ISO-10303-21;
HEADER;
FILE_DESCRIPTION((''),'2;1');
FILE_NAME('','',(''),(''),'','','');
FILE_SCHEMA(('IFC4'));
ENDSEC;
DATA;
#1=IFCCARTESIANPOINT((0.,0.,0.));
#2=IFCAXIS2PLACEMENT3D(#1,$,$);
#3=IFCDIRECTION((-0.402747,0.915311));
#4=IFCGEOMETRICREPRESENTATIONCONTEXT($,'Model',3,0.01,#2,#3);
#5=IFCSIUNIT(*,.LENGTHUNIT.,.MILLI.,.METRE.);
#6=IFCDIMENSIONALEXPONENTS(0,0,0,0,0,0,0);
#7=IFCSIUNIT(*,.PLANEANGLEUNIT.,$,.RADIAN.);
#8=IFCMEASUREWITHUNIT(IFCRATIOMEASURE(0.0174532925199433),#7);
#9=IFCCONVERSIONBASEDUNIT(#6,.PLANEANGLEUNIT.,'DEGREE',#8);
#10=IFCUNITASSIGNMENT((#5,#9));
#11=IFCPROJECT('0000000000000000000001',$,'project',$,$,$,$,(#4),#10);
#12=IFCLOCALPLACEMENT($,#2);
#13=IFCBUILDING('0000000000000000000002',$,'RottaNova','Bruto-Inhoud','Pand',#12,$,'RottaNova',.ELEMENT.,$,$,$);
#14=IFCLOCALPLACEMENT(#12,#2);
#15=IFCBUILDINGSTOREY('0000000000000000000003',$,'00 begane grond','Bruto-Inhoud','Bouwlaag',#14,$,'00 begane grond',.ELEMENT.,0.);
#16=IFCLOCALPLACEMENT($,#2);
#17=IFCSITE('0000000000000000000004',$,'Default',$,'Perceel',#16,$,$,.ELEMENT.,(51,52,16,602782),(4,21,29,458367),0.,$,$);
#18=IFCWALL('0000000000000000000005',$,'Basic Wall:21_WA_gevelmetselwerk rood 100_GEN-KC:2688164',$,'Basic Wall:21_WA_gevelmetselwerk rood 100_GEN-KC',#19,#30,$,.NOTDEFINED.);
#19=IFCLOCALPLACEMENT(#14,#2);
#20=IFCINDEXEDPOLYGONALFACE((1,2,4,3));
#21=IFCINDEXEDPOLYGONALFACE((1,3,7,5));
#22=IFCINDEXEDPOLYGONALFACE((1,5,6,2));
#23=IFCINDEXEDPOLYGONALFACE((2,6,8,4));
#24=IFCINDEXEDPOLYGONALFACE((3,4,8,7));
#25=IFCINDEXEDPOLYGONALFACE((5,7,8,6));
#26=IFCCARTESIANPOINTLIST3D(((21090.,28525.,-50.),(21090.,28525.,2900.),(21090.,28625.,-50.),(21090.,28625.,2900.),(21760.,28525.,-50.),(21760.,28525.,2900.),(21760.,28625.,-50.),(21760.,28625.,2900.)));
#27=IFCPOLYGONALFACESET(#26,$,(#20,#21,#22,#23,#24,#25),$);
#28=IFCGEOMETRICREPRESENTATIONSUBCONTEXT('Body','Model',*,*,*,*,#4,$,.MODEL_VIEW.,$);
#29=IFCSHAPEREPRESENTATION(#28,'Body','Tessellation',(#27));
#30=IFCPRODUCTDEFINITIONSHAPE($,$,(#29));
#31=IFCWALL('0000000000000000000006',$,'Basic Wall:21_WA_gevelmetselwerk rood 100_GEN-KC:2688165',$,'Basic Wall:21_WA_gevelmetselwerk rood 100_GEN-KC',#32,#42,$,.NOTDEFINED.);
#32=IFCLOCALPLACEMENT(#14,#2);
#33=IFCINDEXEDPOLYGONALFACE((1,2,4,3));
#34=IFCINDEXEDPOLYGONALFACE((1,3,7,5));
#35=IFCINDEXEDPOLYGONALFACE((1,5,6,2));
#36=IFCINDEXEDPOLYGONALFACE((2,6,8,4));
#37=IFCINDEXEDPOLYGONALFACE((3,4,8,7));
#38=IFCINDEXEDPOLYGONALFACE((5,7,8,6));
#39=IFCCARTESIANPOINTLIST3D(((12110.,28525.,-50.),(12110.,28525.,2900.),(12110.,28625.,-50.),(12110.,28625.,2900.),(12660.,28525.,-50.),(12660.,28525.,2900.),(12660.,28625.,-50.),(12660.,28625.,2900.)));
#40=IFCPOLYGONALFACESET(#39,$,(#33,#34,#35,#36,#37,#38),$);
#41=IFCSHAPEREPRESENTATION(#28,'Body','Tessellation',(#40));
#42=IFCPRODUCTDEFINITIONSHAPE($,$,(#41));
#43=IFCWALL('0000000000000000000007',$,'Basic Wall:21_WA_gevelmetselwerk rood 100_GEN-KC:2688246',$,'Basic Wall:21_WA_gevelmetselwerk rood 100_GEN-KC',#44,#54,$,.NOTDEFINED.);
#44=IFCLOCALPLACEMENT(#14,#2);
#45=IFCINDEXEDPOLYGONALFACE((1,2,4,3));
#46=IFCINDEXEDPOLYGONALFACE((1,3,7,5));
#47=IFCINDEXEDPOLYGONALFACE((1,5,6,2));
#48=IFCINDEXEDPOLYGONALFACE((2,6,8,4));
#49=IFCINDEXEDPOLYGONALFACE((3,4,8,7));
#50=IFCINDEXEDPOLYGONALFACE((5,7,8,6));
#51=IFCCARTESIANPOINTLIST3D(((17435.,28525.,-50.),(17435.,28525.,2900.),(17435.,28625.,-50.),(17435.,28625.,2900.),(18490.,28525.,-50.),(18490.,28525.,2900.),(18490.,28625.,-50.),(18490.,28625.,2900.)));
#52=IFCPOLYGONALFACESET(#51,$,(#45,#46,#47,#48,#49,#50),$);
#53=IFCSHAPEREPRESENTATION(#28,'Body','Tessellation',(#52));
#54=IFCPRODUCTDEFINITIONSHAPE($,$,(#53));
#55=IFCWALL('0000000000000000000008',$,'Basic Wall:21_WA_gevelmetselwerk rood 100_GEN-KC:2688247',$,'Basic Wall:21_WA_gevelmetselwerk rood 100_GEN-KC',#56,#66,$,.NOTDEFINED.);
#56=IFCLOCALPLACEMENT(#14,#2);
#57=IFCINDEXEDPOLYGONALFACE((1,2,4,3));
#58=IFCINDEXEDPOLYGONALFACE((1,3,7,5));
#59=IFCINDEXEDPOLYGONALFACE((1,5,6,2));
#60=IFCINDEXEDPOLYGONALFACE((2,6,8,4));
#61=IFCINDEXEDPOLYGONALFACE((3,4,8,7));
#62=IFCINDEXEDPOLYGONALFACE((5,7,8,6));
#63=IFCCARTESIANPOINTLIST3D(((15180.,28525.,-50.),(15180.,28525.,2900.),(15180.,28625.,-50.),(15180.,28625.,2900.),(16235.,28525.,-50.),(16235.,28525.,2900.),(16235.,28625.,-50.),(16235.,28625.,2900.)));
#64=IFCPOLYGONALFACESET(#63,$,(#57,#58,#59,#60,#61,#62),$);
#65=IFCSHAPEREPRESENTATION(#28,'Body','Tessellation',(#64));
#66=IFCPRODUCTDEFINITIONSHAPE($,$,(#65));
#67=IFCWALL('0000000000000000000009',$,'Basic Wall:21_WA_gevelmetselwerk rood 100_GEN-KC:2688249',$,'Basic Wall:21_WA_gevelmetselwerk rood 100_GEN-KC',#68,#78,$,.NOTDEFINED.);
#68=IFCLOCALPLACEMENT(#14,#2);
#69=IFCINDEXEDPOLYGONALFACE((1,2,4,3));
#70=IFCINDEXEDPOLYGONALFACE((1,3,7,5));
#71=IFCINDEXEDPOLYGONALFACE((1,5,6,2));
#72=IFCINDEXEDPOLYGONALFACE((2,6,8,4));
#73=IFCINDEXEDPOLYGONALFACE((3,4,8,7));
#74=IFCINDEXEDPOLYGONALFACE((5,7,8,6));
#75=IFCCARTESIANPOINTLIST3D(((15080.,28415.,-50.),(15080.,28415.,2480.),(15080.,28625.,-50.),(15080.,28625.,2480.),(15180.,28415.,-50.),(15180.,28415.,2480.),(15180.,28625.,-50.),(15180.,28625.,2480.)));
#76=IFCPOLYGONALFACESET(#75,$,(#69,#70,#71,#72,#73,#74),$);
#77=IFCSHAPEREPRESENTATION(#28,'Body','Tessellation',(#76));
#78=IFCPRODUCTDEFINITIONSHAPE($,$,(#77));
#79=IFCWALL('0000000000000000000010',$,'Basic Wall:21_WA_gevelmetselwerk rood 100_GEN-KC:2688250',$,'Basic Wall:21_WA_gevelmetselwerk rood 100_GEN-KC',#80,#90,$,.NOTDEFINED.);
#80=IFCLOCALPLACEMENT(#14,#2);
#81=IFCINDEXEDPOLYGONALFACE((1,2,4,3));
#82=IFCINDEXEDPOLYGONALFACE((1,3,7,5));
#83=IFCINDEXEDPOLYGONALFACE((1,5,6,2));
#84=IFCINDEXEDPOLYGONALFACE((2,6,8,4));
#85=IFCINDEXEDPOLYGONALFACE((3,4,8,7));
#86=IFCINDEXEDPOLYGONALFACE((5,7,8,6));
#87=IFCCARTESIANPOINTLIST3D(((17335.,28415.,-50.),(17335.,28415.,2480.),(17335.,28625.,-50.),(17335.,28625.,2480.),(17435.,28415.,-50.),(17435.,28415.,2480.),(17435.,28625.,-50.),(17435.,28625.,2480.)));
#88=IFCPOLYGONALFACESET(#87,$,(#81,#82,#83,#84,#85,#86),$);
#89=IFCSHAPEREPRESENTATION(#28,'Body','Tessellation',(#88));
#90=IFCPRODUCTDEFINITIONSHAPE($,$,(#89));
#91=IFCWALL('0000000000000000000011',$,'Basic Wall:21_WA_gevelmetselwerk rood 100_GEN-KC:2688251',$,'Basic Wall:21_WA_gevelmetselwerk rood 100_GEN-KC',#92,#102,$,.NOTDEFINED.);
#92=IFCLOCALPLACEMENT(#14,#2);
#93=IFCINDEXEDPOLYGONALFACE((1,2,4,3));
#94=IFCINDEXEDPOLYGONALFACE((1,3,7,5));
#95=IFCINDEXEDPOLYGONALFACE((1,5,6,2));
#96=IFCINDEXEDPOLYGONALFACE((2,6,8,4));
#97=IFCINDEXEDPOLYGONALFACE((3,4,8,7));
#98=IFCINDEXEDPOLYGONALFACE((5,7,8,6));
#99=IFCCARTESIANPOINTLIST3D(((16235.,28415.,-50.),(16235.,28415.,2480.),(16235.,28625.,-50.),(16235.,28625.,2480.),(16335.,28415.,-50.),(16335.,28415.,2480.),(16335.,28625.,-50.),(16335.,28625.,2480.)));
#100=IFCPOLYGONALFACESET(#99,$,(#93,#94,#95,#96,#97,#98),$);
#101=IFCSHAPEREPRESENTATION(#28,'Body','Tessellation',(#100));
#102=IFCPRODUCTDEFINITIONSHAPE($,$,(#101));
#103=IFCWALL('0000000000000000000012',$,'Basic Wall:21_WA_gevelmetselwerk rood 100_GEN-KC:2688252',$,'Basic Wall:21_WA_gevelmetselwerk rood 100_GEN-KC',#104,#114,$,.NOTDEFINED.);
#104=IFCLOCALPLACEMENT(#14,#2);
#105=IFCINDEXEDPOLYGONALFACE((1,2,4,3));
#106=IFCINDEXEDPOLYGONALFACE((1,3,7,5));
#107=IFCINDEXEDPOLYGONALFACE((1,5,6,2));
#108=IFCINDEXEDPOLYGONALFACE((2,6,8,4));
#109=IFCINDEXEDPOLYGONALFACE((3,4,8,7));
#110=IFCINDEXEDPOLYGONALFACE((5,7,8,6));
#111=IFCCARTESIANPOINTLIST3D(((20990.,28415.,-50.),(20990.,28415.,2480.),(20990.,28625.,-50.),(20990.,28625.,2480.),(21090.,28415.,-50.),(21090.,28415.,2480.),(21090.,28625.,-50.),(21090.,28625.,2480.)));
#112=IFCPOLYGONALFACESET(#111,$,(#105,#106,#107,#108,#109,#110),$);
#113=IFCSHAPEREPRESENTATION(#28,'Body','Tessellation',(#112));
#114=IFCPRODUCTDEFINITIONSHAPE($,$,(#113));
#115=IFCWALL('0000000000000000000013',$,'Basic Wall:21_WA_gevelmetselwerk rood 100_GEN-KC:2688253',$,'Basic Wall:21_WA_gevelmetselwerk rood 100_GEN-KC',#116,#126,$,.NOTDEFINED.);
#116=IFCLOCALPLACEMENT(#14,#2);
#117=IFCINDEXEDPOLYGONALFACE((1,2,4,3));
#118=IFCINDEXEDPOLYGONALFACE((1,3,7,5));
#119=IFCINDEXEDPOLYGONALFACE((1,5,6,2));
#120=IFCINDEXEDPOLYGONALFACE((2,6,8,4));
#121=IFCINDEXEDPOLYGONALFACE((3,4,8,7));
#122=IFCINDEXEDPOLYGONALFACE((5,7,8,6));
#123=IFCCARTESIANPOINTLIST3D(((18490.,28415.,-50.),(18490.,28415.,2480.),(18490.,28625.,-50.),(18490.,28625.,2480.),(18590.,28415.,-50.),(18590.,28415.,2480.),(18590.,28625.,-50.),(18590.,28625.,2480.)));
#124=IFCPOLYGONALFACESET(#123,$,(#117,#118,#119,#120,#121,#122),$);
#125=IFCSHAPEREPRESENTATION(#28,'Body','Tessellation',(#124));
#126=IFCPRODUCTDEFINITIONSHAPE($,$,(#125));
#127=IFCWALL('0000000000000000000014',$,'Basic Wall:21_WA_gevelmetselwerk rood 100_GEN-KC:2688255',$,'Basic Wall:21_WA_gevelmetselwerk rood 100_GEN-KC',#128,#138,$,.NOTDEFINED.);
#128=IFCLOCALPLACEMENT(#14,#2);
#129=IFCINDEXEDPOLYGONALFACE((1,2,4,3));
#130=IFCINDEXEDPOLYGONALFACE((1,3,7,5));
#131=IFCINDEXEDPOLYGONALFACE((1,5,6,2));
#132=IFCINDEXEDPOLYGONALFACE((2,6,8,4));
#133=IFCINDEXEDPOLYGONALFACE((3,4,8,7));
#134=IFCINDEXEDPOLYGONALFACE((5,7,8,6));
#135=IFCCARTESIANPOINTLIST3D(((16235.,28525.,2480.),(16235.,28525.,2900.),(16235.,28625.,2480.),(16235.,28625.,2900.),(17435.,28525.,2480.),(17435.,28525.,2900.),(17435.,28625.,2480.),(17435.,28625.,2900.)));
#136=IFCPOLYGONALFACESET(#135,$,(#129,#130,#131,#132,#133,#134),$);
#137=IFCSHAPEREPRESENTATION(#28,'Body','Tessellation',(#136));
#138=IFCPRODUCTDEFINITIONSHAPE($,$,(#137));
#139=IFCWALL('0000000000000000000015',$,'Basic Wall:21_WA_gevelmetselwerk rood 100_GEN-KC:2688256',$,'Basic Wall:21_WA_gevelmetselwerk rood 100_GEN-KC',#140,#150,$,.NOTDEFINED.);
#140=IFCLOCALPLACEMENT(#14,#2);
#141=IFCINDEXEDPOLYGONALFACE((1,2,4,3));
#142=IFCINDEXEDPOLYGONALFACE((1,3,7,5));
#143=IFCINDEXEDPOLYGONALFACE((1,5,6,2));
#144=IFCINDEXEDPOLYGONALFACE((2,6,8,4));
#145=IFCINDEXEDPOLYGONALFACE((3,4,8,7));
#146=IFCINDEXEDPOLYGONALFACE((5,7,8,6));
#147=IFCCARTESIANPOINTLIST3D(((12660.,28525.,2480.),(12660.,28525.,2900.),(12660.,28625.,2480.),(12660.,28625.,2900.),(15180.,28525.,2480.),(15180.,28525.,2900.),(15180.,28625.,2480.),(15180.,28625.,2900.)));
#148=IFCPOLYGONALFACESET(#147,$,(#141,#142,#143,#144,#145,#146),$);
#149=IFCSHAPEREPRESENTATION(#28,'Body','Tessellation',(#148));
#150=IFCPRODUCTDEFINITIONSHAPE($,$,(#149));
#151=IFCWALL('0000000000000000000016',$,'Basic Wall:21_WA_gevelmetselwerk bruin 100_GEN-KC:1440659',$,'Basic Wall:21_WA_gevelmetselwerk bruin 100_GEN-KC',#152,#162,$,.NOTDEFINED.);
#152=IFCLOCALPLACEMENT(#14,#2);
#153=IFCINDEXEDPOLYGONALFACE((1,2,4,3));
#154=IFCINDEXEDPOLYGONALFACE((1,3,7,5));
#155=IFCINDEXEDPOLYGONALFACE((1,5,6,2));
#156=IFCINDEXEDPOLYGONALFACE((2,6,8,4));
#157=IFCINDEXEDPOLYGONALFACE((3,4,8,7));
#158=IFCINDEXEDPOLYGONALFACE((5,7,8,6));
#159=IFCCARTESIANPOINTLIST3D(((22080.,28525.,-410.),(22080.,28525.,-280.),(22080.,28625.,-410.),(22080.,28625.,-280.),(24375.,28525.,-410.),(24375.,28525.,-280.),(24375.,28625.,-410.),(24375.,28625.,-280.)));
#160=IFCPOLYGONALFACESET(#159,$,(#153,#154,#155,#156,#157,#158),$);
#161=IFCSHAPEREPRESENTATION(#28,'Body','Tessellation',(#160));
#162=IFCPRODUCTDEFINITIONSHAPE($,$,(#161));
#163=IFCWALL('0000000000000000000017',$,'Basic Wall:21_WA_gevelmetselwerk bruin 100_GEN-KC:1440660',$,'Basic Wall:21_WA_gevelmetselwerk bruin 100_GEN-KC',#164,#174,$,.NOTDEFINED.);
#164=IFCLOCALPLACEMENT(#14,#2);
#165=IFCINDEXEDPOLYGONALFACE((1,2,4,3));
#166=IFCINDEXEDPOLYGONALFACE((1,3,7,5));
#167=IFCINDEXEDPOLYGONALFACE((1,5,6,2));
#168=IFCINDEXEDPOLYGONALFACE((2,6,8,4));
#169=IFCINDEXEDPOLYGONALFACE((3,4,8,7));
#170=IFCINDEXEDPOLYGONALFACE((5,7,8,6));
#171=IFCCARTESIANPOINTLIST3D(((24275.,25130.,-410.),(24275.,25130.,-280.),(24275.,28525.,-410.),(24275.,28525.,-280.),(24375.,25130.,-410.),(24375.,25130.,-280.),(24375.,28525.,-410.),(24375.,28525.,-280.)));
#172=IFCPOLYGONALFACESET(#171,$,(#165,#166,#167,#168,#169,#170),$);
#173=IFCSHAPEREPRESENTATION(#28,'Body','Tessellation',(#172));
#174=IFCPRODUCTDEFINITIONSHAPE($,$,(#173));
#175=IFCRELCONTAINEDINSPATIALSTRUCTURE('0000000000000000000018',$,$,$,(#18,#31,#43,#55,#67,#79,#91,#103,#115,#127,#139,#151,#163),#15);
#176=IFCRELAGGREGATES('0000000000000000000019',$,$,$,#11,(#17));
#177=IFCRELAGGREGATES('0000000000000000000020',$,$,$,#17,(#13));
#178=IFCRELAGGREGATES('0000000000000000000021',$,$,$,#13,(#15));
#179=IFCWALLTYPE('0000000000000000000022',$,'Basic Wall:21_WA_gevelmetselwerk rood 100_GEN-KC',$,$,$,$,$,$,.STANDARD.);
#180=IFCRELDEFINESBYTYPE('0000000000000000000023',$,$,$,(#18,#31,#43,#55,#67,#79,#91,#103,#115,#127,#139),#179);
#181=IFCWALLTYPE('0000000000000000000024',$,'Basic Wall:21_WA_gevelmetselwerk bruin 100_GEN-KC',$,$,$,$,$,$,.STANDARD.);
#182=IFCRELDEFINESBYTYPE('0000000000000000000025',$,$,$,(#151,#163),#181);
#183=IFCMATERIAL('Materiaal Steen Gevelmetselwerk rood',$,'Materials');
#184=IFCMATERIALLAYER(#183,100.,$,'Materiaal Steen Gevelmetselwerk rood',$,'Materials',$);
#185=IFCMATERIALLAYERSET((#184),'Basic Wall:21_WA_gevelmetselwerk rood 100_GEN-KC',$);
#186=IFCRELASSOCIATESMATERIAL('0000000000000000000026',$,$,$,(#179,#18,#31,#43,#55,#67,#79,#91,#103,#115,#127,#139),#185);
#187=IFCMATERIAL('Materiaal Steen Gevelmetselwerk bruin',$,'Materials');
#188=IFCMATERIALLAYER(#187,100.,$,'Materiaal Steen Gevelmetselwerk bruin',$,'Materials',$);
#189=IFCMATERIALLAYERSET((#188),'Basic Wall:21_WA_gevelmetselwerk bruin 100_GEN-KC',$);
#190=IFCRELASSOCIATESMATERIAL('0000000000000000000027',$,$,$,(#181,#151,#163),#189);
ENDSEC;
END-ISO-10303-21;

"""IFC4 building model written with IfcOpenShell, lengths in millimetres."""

from ifc_helpers import new_model, entity, si_unit, converted_unit, direction, frame, frame_2d, origin, place, context, subcontext, project, spatial, rectangle, extrude, material, layer, layer_set, type_object, element, save


model = new_model("IFC4")

# Units and contexts
model_context = context("Model", 3, precision=0.01, world=origin(), true_north=direction((-0.402747, 0.915311)))
body_context = subcontext(model_context, "Body", "Model", "MODEL_VIEW")
ifc_project = project(units=[si_unit("LENGTHUNIT", "METRE", prefix="MILLI"), converted_unit("PLANEANGLEUNIT", "DEGREE", entity("IfcRatioMeasure", 0.0174532925199433), si_unit("PLANEANGLEUNIT", "RADIAN"), dimensions=[0, 0, 0, 0, 0, 0, 0])], contexts=[model_context])

# Site, building, storey
site_placement = place(None, origin())
site = spatial("IfcSite", under=ifc_project, at=site_placement, Name="Default", ObjectType="Perceel", CompositionType="ELEMENT", RefLatitude=(51, 52, 16, 602782), RefLongitude=(4, 21, 29, 458367), RefElevation=0.0)
building_placement = place(None, origin())
building = spatial("IfcBuilding", under=site, at=building_placement, Name="RottaNova", Description="Bruto-Inhoud", ObjectType="Pand", LongName="RottaNova", CompositionType="ELEMENT")
storey_placement = place(building_placement, origin())
storey = spatial("IfcBuildingStorey", under=building, at=storey_placement, Name="00 begane grond", Description="Bruto-Inhoud", ObjectType="Bouwlaag", LongName="00 begane grond", CompositionType="ELEMENT", Elevation=0.0)

# Walls
ifc_material_1 = material(Name="Materiaal Steen Gevelmetselwerk rood", Category="Materials")
ifc_layer_1 = layer(ifc_material_1, 100.0, Name="Materiaal Steen Gevelmetselwerk rood", Category="Materials")
ifc_layer_set_1 = layer_set([ifc_layer_1], Name="Basic Wall:21_WA_gevelmetselwerk rood 100_GEN-KC")
wall_type_1 = type_object("IfcWallType", Name="Basic Wall:21_WA_gevelmetselwerk rood 100_GEN-KC", PredefinedType="STANDARD", material=ifc_layer_set_1)
wall_1_placement = place(storey_placement, frame((21760.0, 28575.0, -50.0), z_axis=(0.0, 0.0, 1.0), x_axis=(-1.0, 0.0, 0.0)))
element("IfcWall", 1, at=wall_1_placement, inside=storey, type_object=wall_type_1, material=ifc_layer_set_1, Name="Basic Wall:21_WA_gevelmetselwerk rood 100_GEN-KC:2688164", ObjectType="Basic Wall:21_WA_gevelmetselwerk rood 100_GEN-KC", PredefinedType="NOTDEFINED", context=body_context, shape_type="SweptSolid", body=[
    extrude(rectangle(XDim=670.0, YDim=100.0, at=frame_2d((335.0, 0.0), x_axis=(-1.0, 0.0))), origin(), (0.0, 0.0, 1.0), 2950.0),
])
wall_2_placement = place(storey_placement, frame((12660.0, 28575.0, -50.0), z_axis=(0.0, 0.0, 1.0), x_axis=(-1.0, 0.0, 0.0)))
element("IfcWall", 2, at=wall_2_placement, inside=storey, type_object=wall_type_1, material=ifc_layer_set_1, Name="Basic Wall:21_WA_gevelmetselwerk rood 100_GEN-KC:2688165", ObjectType="Basic Wall:21_WA_gevelmetselwerk rood 100_GEN-KC", PredefinedType="NOTDEFINED", context=body_context, shape_type="SweptSolid", body=[
    extrude(rectangle(XDim=550.0, YDim=100.0, at=frame_2d((275.0, 0.0), x_axis=(-1.0, 0.0))), origin(), (0.0, 0.0, 1.0), 2950.0),
])
wall_3_placement = place(storey_placement, frame((18490.0, 28575.0, -50.0), z_axis=(0.0, 0.0, 1.0), x_axis=(-1.0, 0.0, 0.0)))
element("IfcWall", 3, at=wall_3_placement, inside=storey, type_object=wall_type_1, material=ifc_layer_set_1, Name="Basic Wall:21_WA_gevelmetselwerk rood 100_GEN-KC:2688246", ObjectType="Basic Wall:21_WA_gevelmetselwerk rood 100_GEN-KC", PredefinedType="NOTDEFINED", context=body_context, shape_type="SweptSolid", body=[
    extrude(rectangle(XDim=1055.0, YDim=100.0, at=frame_2d((527.5, 0.0), x_axis=(-1.0, 0.0))), origin(), (0.0, 0.0, 1.0), 2950.0),
])
wall_4_placement = place(storey_placement, frame((16235.0, 28575.0, -50.0), z_axis=(0.0, 0.0, 1.0), x_axis=(-1.0, 0.0, 0.0)))
element("IfcWall", 4, at=wall_4_placement, inside=storey, type_object=wall_type_1, material=ifc_layer_set_1, Name="Basic Wall:21_WA_gevelmetselwerk rood 100_GEN-KC:2688247", ObjectType="Basic Wall:21_WA_gevelmetselwerk rood 100_GEN-KC", PredefinedType="NOTDEFINED", context=body_context, shape_type="SweptSolid", body=[
    extrude(rectangle(XDim=1055.0, YDim=100.0, at=frame_2d((527.5, 0.0), x_axis=(-1.0, 0.0))), origin(), (0.0, 0.0, 1.0), 2950.0),
])
wall_5_placement = place(storey_placement, frame((15130.0, 28415.0, -50.0), z_axis=(0.0, 0.0, 1.0), x_axis=(0.0, 1.0, 0.0)))
element("IfcWall", 5, at=wall_5_placement, inside=storey, type_object=wall_type_1, material=ifc_layer_set_1, Name="Basic Wall:21_WA_gevelmetselwerk rood 100_GEN-KC:2688249", ObjectType="Basic Wall:21_WA_gevelmetselwerk rood 100_GEN-KC", PredefinedType="NOTDEFINED", context=body_context, shape_type="SweptSolid", body=[
    extrude(rectangle(XDim=210.0, YDim=100.0, at=frame_2d((105.0, 0.0), x_axis=(-1.0, 0.0))), origin(), (0.0, 0.0, 1.0), 2530.0),
])
for number, where, z_axis, x_axis, name in (
    (6, (17385.0, 28415.0, -50.0), (0.0, 0.0, 1.0), (0.0, 1.0, 0.0), "Basic Wall:21_WA_gevelmetselwerk rood 100_GEN-KC:2688250"),
    (7, (16285.0, 28415.0, -50.0), (0.0, 0.0, 1.0), (0.0, 1.0, 0.0), "Basic Wall:21_WA_gevelmetselwerk rood 100_GEN-KC:2688251"),
):
    element("IfcWall", number, at=place(storey_placement, frame(where, z_axis=z_axis, x_axis=x_axis)), inside=storey, type_object=wall_type_1, material=ifc_layer_set_1, Name=name, ObjectType="Basic Wall:21_WA_gevelmetselwerk rood 100_GEN-KC", PredefinedType="NOTDEFINED", context=body_context, shape_type="SweptSolid", body=[
        extrude(rectangle(XDim=210.0, YDim=100.0, at=frame_2d((105.0, 0.0), x_axis=(-1.0, 0.0))), origin(), (0.0, 0.0, 1.0), 2530.0),
    ])
wall_6_placement = place(storey_placement, frame((21040.0, 28415.0, -50.0), z_axis=(0.0, 0.0, 1.0), x_axis=(0.0, 1.0, 0.0)))
element("IfcWall", 8, at=wall_6_placement, inside=storey, type_object=wall_type_1, material=ifc_layer_set_1, Name="Basic Wall:21_WA_gevelmetselwerk rood 100_GEN-KC:2688252", ObjectType="Basic Wall:21_WA_gevelmetselwerk rood 100_GEN-KC", PredefinedType="NOTDEFINED", context=body_context, shape_type="SweptSolid", body=[
    extrude(rectangle(XDim=210.0, YDim=100.0, at=frame_2d((105.0, 0.0), x_axis=(-1.0, 0.0))), origin(), (0.0, 0.0, 1.0), 2530.0),
])
wall_7_placement = place(storey_placement, frame((18540.0, 28415.0, -50.0), z_axis=(0.0, 0.0, 1.0), x_axis=(0.0, 1.0, 0.0)))
element("IfcWall", 9, at=wall_7_placement, inside=storey, type_object=wall_type_1, material=ifc_layer_set_1, Name="Basic Wall:21_WA_gevelmetselwerk rood 100_GEN-KC:2688253", ObjectType="Basic Wall:21_WA_gevelmetselwerk rood 100_GEN-KC", PredefinedType="NOTDEFINED", context=body_context, shape_type="SweptSolid", body=[
    extrude(rectangle(XDim=210.0, YDim=100.0, at=frame_2d((105.0, 0.0), x_axis=(-1.0, 0.0))), origin(), (0.0, 0.0, 1.0), 2530.0),
])
wall_8_placement = place(storey_placement, frame((17435.0, 28575.0, 2480.0), z_axis=(0.0, 0.0, 1.0), x_axis=(-1.0, 0.0, 0.0)))
element("IfcWall", 10, at=wall_8_placement, inside=storey, type_object=wall_type_1, material=ifc_layer_set_1, Name="Basic Wall:21_WA_gevelmetselwerk rood 100_GEN-KC:2688255", ObjectType="Basic Wall:21_WA_gevelmetselwerk rood 100_GEN-KC", PredefinedType="NOTDEFINED", context=body_context, shape_type="SweptSolid", body=[
    extrude(rectangle(XDim=1200.0, YDim=100.0, at=frame_2d((600.0, 0.0), x_axis=(-1.0, 0.0))), origin(), (0.0, 0.0, 1.0), 420.0),
])
wall_9_placement = place(storey_placement, frame((15180.0, 28575.0, 2480.0), z_axis=(0.0, 0.0, 1.0), x_axis=(-1.0, 0.0, 0.0)))
element("IfcWall", 11, at=wall_9_placement, inside=storey, type_object=wall_type_1, material=ifc_layer_set_1, Name="Basic Wall:21_WA_gevelmetselwerk rood 100_GEN-KC:2688256", ObjectType="Basic Wall:21_WA_gevelmetselwerk rood 100_GEN-KC", PredefinedType="NOTDEFINED", context=body_context, shape_type="SweptSolid", body=[
    extrude(rectangle(XDim=2520.0, YDim=100.0, at=frame_2d((1260.0, 0.0), x_axis=(-1.0, 0.0))), origin(), (0.0, 0.0, 1.0), 420.0),
])
ifc_material_2 = material(Name="Materiaal Steen Gevelmetselwerk bruin", Category="Materials")
ifc_layer_2 = layer(ifc_material_2, 100.0, Name="Materiaal Steen Gevelmetselwerk bruin", Category="Materials")
ifc_layer_set_2 = layer_set([ifc_layer_2], Name="Basic Wall:21_WA_gevelmetselwerk bruin 100_GEN-KC")
wall_type_2 = type_object("IfcWallType", Name="Basic Wall:21_WA_gevelmetselwerk bruin 100_GEN-KC", PredefinedType="STANDARD", material=ifc_layer_set_2)
wall_10_placement = place(storey_placement, frame((22080.0, 28575.0, -410.0)))
element("IfcWall", 12, at=wall_10_placement, inside=storey, type_object=wall_type_2, material=ifc_layer_set_2, Name="Basic Wall:21_WA_gevelmetselwerk bruin 100_GEN-KC:1440659", ObjectType="Basic Wall:21_WA_gevelmetselwerk bruin 100_GEN-KC", PredefinedType="NOTDEFINED", context=body_context, shape_type="SweptSolid", body=[
    extrude(rectangle(XDim=2295.0, YDim=100.0, at=frame_2d((1147.5, 0.0), x_axis=(-1.0, 0.0))), origin(), (0.0, 0.0, 1.0), 130.0),
])
wall_11_placement = place(storey_placement, frame((24325.0, 25130.0, -410.0), z_axis=(0.0, 0.0, 1.0), x_axis=(0.0, 1.0, 0.0)))
element("IfcWall", 13, at=wall_11_placement, inside=storey, type_object=wall_type_2, material=ifc_layer_set_2, Name="Basic Wall:21_WA_gevelmetselwerk bruin 100_GEN-KC:1440660", ObjectType="Basic Wall:21_WA_gevelmetselwerk bruin 100_GEN-KC", PredefinedType="NOTDEFINED", context=body_context, shape_type="SweptSolid", body=[
    extrude(rectangle(XDim=3395.0, YDim=100.0, at=frame_2d((1697.5, 0.0), x_axis=(-1.0, 0.0))), origin(), (0.0, 0.0, 1.0), 130.0),
])

save(model, "model.ifc")
